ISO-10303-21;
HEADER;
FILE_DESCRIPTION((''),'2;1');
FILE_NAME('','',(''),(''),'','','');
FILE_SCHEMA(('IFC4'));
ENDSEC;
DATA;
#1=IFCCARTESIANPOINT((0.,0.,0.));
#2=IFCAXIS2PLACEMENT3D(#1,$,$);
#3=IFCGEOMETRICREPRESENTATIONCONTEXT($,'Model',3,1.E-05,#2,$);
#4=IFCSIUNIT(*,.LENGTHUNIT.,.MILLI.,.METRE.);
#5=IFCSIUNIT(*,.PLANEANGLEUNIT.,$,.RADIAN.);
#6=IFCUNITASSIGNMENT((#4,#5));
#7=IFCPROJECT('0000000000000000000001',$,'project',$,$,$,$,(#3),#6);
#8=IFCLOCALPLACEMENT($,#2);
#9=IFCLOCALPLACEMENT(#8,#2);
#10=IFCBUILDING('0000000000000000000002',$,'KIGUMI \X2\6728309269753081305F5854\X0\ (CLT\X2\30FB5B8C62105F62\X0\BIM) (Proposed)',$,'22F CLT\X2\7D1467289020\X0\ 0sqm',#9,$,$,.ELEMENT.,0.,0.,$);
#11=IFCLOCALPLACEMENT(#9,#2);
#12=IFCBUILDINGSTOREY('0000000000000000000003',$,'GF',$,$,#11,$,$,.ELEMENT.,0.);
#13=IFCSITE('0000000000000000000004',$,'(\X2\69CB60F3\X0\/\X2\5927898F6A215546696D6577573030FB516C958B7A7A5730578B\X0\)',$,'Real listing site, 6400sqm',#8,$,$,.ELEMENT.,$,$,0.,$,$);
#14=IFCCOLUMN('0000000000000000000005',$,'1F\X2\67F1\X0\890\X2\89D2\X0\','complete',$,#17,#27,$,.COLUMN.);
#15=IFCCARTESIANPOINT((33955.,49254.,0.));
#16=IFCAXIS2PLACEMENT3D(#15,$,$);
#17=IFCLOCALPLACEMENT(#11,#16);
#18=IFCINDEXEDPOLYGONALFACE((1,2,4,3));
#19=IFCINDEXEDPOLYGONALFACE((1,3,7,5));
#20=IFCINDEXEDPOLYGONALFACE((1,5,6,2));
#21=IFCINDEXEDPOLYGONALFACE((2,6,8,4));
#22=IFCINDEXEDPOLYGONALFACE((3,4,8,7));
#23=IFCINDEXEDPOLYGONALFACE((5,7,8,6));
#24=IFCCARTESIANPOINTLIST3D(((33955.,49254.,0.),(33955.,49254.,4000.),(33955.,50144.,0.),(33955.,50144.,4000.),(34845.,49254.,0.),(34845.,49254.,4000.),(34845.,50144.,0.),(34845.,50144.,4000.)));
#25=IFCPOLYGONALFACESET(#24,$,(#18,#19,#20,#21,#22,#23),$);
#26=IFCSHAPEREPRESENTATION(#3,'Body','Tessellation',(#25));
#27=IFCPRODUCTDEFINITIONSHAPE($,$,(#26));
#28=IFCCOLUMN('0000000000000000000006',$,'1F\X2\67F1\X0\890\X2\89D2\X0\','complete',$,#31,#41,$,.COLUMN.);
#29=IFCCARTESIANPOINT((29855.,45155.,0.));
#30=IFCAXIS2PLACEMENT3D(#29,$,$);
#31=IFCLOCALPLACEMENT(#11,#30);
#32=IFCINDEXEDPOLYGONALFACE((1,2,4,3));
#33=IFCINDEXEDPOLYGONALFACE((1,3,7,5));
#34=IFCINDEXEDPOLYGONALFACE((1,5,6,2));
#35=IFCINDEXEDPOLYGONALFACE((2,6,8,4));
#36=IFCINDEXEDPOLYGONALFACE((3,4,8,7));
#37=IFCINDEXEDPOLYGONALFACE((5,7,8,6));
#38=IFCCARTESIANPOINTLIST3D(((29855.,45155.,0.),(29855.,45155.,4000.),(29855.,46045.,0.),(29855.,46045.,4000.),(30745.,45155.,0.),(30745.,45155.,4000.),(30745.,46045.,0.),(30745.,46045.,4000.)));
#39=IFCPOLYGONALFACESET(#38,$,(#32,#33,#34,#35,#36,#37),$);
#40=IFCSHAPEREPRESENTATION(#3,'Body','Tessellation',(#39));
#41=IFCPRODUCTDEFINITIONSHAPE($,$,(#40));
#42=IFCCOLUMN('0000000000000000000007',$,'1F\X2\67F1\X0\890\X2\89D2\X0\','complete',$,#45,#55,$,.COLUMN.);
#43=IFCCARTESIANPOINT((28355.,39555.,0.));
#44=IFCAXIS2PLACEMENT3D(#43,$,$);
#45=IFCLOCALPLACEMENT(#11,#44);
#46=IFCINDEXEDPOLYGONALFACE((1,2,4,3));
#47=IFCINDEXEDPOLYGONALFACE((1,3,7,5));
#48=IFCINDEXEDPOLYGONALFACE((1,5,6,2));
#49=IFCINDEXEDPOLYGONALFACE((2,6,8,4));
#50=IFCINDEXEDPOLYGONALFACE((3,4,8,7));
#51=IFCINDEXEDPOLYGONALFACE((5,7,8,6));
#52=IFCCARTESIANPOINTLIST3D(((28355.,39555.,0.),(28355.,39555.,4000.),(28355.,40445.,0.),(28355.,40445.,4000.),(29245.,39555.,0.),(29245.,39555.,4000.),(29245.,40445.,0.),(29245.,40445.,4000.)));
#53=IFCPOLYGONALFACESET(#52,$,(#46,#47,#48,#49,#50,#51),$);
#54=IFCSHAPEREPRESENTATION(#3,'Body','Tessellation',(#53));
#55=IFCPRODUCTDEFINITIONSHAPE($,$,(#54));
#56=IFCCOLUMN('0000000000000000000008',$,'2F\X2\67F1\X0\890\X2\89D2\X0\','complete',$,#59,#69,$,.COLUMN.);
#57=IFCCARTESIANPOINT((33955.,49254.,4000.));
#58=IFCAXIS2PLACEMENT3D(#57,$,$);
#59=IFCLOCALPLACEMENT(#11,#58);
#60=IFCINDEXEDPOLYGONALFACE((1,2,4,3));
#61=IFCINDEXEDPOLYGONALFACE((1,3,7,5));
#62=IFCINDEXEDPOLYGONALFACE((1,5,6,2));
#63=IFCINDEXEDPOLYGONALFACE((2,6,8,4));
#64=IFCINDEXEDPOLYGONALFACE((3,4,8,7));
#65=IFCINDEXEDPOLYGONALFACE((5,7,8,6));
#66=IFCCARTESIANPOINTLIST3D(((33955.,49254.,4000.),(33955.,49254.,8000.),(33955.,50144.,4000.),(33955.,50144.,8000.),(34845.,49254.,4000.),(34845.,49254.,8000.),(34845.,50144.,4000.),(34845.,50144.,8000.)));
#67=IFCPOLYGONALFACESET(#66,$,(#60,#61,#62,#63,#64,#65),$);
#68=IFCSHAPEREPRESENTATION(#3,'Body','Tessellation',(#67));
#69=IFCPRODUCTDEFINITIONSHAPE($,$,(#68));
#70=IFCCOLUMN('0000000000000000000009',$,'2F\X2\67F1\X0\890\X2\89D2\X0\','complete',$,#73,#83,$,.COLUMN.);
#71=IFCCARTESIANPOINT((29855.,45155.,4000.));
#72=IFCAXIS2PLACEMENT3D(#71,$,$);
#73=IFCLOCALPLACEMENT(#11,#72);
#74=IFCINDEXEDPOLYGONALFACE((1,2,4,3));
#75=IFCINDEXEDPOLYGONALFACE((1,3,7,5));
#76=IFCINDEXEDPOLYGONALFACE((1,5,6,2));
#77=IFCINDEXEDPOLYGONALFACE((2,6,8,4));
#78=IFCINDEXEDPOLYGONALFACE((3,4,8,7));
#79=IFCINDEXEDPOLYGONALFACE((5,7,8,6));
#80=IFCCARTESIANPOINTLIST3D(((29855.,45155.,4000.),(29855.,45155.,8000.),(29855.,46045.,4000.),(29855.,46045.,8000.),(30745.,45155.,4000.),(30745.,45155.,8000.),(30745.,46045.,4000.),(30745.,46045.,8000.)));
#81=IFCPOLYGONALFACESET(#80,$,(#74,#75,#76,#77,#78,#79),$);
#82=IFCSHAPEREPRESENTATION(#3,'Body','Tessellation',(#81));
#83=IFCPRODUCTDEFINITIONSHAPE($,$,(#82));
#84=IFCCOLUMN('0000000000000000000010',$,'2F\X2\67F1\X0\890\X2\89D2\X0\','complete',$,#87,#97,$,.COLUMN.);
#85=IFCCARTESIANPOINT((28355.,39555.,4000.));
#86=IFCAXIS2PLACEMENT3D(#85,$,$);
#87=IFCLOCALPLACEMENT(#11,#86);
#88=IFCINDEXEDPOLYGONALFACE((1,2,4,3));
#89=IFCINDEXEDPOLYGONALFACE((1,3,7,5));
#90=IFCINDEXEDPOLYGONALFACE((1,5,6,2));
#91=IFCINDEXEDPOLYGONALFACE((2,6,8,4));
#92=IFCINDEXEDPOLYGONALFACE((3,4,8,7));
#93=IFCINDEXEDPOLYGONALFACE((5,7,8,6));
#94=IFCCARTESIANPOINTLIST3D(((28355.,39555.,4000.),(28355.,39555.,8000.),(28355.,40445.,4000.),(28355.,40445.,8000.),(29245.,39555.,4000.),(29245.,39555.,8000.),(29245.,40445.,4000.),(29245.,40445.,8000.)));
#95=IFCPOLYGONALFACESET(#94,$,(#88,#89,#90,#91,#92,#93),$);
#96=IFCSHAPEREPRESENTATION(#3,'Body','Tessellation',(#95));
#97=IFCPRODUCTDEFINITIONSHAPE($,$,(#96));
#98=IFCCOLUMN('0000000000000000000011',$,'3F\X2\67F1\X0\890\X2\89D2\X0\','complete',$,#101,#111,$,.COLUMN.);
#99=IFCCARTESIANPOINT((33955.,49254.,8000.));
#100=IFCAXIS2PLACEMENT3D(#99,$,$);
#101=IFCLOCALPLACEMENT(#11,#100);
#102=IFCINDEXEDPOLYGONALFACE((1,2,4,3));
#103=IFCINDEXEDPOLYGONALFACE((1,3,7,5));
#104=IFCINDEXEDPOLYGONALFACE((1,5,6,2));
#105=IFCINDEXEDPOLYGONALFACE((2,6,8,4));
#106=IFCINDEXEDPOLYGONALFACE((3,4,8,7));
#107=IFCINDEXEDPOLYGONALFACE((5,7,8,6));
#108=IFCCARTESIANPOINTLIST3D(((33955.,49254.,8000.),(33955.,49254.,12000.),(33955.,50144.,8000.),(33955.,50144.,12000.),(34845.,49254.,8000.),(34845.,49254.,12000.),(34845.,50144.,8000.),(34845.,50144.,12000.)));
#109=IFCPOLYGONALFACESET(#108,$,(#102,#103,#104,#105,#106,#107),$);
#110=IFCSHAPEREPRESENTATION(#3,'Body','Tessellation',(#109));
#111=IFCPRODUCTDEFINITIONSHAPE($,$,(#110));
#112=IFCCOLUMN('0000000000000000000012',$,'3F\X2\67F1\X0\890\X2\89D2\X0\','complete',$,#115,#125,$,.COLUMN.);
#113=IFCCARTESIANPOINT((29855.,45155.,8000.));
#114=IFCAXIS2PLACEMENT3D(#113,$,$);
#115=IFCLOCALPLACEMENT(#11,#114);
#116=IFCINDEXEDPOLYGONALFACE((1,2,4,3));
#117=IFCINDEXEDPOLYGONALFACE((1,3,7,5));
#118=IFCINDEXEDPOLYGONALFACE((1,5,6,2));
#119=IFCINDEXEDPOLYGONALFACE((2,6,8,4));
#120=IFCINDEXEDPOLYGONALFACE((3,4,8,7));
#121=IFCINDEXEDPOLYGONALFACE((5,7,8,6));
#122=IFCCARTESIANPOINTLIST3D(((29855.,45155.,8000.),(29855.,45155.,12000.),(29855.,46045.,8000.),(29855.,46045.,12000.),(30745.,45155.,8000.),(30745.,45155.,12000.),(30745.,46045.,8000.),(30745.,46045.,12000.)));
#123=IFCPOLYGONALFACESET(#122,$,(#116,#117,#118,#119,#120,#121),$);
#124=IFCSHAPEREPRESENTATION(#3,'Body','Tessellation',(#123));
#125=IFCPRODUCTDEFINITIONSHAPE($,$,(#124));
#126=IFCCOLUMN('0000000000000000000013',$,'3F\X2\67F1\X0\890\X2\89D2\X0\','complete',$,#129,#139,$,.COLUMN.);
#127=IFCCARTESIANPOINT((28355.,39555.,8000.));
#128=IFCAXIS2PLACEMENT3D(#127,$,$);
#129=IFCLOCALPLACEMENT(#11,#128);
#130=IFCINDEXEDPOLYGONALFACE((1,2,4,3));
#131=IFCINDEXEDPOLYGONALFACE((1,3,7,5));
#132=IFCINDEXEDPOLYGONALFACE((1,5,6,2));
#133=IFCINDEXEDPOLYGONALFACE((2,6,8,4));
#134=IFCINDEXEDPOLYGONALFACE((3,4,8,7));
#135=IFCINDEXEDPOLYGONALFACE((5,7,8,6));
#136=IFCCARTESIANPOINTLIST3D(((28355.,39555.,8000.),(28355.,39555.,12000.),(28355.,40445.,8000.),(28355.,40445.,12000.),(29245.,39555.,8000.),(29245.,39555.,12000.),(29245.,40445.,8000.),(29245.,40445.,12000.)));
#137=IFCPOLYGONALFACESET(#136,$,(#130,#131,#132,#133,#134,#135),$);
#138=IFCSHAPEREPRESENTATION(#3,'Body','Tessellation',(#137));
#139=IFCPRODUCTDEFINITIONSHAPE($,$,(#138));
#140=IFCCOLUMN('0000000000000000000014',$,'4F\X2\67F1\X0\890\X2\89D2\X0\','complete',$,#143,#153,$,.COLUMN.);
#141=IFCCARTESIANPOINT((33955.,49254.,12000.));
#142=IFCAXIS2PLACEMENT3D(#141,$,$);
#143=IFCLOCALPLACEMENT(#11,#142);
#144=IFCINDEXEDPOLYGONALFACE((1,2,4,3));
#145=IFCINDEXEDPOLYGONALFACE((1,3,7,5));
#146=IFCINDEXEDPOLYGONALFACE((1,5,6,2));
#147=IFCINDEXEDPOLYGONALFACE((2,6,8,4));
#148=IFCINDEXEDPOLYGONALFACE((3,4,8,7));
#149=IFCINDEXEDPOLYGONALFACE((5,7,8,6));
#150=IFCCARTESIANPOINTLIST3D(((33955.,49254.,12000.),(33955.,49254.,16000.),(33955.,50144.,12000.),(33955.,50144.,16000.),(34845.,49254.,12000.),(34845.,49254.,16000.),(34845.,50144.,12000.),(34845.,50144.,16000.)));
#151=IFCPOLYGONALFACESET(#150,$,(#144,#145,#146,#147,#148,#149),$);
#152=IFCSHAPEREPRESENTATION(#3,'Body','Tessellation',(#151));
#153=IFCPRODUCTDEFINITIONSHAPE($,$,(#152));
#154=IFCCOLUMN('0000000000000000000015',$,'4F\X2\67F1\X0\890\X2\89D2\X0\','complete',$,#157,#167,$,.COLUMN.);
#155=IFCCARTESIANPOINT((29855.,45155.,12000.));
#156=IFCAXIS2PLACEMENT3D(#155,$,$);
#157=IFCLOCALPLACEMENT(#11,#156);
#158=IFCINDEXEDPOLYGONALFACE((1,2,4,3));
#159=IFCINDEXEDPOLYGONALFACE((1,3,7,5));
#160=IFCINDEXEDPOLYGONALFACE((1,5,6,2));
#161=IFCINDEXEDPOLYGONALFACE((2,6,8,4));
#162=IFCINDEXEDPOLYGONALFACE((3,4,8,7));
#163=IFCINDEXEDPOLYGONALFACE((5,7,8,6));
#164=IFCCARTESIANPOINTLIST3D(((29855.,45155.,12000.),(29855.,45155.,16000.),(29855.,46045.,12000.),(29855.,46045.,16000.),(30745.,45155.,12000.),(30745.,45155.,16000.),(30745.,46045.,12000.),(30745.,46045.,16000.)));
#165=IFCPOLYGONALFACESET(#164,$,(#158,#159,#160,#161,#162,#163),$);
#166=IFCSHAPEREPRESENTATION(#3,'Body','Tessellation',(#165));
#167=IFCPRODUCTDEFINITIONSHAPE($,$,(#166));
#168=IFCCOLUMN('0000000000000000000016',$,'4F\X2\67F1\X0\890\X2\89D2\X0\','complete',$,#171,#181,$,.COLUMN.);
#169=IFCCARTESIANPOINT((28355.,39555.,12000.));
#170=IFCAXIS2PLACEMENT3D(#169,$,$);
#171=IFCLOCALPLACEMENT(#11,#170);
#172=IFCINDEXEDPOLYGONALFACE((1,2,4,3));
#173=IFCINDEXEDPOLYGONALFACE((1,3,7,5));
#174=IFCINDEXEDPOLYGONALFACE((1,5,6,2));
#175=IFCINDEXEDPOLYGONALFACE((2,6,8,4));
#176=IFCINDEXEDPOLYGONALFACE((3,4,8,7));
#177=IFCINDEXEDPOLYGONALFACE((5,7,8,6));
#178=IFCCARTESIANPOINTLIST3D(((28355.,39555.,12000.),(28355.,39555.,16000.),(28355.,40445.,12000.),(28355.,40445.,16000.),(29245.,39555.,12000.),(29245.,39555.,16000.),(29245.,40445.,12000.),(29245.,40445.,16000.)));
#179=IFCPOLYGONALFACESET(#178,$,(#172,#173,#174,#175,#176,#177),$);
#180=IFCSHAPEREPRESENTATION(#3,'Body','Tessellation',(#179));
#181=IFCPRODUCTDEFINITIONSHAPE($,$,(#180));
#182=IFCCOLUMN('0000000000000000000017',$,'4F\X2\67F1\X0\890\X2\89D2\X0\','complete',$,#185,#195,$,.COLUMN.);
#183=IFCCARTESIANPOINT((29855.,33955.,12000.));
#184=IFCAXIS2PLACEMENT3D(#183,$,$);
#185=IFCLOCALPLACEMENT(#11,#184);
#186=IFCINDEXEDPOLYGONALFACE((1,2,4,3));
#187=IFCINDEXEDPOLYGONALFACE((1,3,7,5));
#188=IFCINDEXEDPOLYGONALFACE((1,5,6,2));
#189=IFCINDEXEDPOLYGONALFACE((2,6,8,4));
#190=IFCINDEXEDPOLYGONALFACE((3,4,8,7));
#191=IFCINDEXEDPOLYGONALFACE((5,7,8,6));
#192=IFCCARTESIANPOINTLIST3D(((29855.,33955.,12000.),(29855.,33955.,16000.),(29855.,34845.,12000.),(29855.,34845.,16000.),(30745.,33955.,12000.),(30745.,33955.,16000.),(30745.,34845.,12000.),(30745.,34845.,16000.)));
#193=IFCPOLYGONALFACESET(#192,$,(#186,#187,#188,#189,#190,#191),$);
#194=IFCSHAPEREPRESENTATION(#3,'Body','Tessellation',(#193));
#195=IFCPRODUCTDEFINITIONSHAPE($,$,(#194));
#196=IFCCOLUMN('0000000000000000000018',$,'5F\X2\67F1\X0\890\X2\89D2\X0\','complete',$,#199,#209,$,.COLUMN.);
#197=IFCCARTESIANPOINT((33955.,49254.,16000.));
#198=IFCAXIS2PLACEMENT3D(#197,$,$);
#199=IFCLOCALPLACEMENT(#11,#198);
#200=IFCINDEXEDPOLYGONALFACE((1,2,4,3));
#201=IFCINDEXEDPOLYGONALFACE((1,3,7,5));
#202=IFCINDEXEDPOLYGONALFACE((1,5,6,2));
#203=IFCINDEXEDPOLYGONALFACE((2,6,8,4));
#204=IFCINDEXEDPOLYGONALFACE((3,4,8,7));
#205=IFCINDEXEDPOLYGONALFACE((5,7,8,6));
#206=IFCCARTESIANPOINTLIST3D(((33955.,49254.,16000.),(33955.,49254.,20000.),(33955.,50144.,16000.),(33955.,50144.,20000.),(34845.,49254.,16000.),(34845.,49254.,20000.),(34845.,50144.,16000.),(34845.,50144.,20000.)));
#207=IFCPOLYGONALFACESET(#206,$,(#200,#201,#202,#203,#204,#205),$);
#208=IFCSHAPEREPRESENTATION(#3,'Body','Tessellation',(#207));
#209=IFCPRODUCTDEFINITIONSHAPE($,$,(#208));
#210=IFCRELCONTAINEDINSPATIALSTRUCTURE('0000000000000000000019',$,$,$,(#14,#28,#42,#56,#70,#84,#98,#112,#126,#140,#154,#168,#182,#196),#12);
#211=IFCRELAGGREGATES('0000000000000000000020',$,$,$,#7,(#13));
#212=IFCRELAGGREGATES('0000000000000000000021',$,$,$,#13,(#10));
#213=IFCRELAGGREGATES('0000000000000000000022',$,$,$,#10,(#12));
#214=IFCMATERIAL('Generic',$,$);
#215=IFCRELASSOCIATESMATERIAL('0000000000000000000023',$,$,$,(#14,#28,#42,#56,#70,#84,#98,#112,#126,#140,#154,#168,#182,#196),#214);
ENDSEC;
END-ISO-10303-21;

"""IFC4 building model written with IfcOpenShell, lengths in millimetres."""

from ifc_helpers import new_model, si_unit, frame, frame_2d, origin, place, context, project, spatial, rectangle, extrude, material, element, save


model = new_model("IFC4")

# Units and contexts
model_context = context("Model", 3, precision=1e-05, world=origin())
ifc_project = project(units=[si_unit("LENGTHUNIT", "METRE", prefix="MILLI"), si_unit("PLANEANGLEUNIT", "RADIAN")], contexts=[model_context])

# Site, building, storey
site_placement = place(None, origin())
site = spatial("IfcSite", under=ifc_project, at=site_placement, Name="(構想/大規模商業敷地・公開空地型)", ObjectType="Real listing site, 6400sqm", CompositionType="ELEMENT", RefElevation=0.0)
building_placement = place(site_placement, origin())
building = spatial("IfcBuilding", under=site, at=building_placement, Name="KIGUMI 木を極めた塔 (CLT・完成形BIM) (Proposed)", ObjectType="22F CLT純木造 0sqm", CompositionType="ELEMENT", ElevationOfRefHeight=0.0, ElevationOfTerrain=0.0)
storey_placement = place(building_placement, origin())
storey = spatial("IfcBuildingStorey", under=building, at=storey_placement, Name="GF", CompositionType="ELEMENT", Elevation=0.0)

# Columns
ifc_material = material(Name="Generic")
column_1_placement = place(storey_placement, frame((33955.0, 49254.0, 0.0)))
element("IfcColumn", 1, at=column_1_placement, inside=storey, material=ifc_material, Name="1F柱890角", Description="complete", PredefinedType="COLUMN", context=model_context, shape_type="SweptSolid", body=[
    extrude(rectangle(XDim=890.0, YDim=890.0, at=frame_2d((445.0, 445.0))), frame((33955.0, 49254.0, 0.0)), (0.0, 0.0, 1.0), 4000.0),
])
column_2_placement = place(storey_placement, frame((29855.0, 45155.0, 0.0)))
element("IfcColumn", 2, at=column_2_placement, inside=storey, material=ifc_material, Name="1F柱890角", Description="complete", PredefinedType="COLUMN", context=model_context, shape_type="SweptSolid", body=[
    extrude(rectangle(XDim=890.0, YDim=890.0, at=frame_2d((445.0, 445.0))), frame((29855.0, 45155.0, 0.0)), (0.0, 0.0, 1.0), 4000.0),
])
column_3_placement = place(storey_placement, frame((28355.0, 39555.0, 0.0)))
element("IfcColumn", 3, at=column_3_placement, inside=storey, material=ifc_material, Name="1F柱890角", Description="complete", PredefinedType="COLUMN", context=model_context, shape_type="SweptSolid", body=[
    extrude(rectangle(XDim=890.0, YDim=890.0, at=frame_2d((445.0, 445.0))), frame((28355.0, 39555.0, 0.0)), (0.0, 0.0, 1.0), 4000.0),
])
column_4_placement = place(storey_placement, frame((33955.0, 49254.0, 4000.0)))
element("IfcColumn", 4, at=column_4_placement, inside=storey, material=ifc_material, Name="2F柱890角", Description="complete", PredefinedType="COLUMN", context=model_context, shape_type="SweptSolid", body=[
    extrude(rectangle(XDim=890.0, YDim=890.0, at=frame_2d((445.0, 445.0))), frame((33955.0, 49254.0, 4000.0)), (0.0, 0.0, 1.0), 4000.0),
])
column_5_placement = place(storey_placement, frame((29855.0, 45155.0, 4000.0)))
element("IfcColumn", 5, at=column_5_placement, inside=storey, material=ifc_material, Name="2F柱890角", Description="complete", PredefinedType="COLUMN", context=model_context, shape_type="SweptSolid", body=[
    extrude(rectangle(XDim=890.0, YDim=890.0, at=frame_2d((445.0, 445.0))), frame((29855.0, 45155.0, 4000.0)), (0.0, 0.0, 1.0), 4000.0),
])
column_6_placement = place(storey_placement, frame((28355.0, 39555.0, 4000.0)))
element("IfcColumn", 6, at=column_6_placement, inside=storey, material=ifc_material, Name="2F柱890角", Description="complete", PredefinedType="COLUMN", context=model_context, shape_type="SweptSolid", body=[
    extrude(rectangle(XDim=890.0, YDim=890.0, at=frame_2d((445.0, 445.0))), frame((28355.0, 39555.0, 4000.0)), (0.0, 0.0, 1.0), 4000.0),
])
column_7_placement = place(storey_placement, frame((33955.0, 49254.0, 8000.0)))
element("IfcColumn", 7, at=column_7_placement, inside=storey, material=ifc_material, Name="3F柱890角", Description="complete", PredefinedType="COLUMN", context=model_context, shape_type="SweptSolid", body=[
    extrude(rectangle(XDim=890.0, YDim=890.0, at=frame_2d((445.0, 445.0))), frame((33955.0, 49254.0, 8000.0)), (0.0, 0.0, 1.0), 4000.0),
])
column_8_placement = place(storey_placement, frame((29855.0, 45155.0, 8000.0)))
element("IfcColumn", 8, at=column_8_placement, inside=storey, material=ifc_material, Name="3F柱890角", Description="complete", PredefinedType="COLUMN", context=model_context, shape_type="SweptSolid", body=[
    extrude(rectangle(XDim=890.0, YDim=890.0, at=frame_2d((445.0, 445.0))), frame((29855.0, 45155.0, 8000.0)), (0.0, 0.0, 1.0), 4000.0),
])
column_9_placement = place(storey_placement, frame((28355.0, 39555.0, 8000.0)))
element("IfcColumn", 9, at=column_9_placement, inside=storey, material=ifc_material, Name="3F柱890角", Description="complete", PredefinedType="COLUMN", context=model_context, shape_type="SweptSolid", body=[
    extrude(rectangle(XDim=890.0, YDim=890.0, at=frame_2d((445.0, 445.0))), frame((28355.0, 39555.0, 8000.0)), (0.0, 0.0, 1.0), 4000.0),
])
column_10_placement = place(storey_placement, frame((33955.0, 49254.0, 12000.0)))
element("IfcColumn", 10, at=column_10_placement, inside=storey, material=ifc_material, Name="4F柱890角", Description="complete", PredefinedType="COLUMN", context=model_context, shape_type="SweptSolid", body=[
    extrude(rectangle(XDim=890.0, YDim=890.0, at=frame_2d((445.0, 445.0))), frame((33955.0, 49254.0, 12000.0)), (0.0, 0.0, 1.0), 4000.0),
])
column_11_placement = place(storey_placement, frame((29855.0, 45155.0, 12000.0)))
element("IfcColumn", 11, at=column_11_placement, inside=storey, material=ifc_material, Name="4F柱890角", Description="complete", PredefinedType="COLUMN", context=model_context, shape_type="SweptSolid", body=[
    extrude(rectangle(XDim=890.0, YDim=890.0, at=frame_2d((445.0, 445.0))), frame((29855.0, 45155.0, 12000.0)), (0.0, 0.0, 1.0), 4000.0),
])
column_12_placement = place(storey_placement, frame((28355.0, 39555.0, 12000.0)))
element("IfcColumn", 12, at=column_12_placement, inside=storey, material=ifc_material, Name="4F柱890角", Description="complete", PredefinedType="COLUMN", context=model_context, shape_type="SweptSolid", body=[
    extrude(rectangle(XDim=890.0, YDim=890.0, at=frame_2d((445.0, 445.0))), frame((28355.0, 39555.0, 12000.0)), (0.0, 0.0, 1.0), 4000.0),
])
column_13_placement = place(storey_placement, frame((29855.0, 33955.0, 12000.0)))
element("IfcColumn", 13, at=column_13_placement, inside=storey, material=ifc_material, Name="4F柱890角", Description="complete", PredefinedType="COLUMN", context=model_context, shape_type="SweptSolid", body=[
    extrude(rectangle(XDim=890.0, YDim=890.0, at=frame_2d((445.0, 445.0))), frame((29855.0, 33955.0, 12000.0)), (0.0, 0.0, 1.0), 4000.0),
])
column_14_placement = place(storey_placement, frame((33955.0, 49254.0, 16000.0)))
element("IfcColumn", 14, at=column_14_placement, inside=storey, material=ifc_material, Name="5F柱890角", Description="complete", PredefinedType="COLUMN", context=model_context, shape_type="SweptSolid", body=[
    extrude(rectangle(XDim=890.0, YDim=890.0, at=frame_2d((445.0, 445.0))), frame((33955.0, 49254.0, 16000.0)), (0.0, 0.0, 1.0), 4000.0),
])

save(model, "model.ifc")
